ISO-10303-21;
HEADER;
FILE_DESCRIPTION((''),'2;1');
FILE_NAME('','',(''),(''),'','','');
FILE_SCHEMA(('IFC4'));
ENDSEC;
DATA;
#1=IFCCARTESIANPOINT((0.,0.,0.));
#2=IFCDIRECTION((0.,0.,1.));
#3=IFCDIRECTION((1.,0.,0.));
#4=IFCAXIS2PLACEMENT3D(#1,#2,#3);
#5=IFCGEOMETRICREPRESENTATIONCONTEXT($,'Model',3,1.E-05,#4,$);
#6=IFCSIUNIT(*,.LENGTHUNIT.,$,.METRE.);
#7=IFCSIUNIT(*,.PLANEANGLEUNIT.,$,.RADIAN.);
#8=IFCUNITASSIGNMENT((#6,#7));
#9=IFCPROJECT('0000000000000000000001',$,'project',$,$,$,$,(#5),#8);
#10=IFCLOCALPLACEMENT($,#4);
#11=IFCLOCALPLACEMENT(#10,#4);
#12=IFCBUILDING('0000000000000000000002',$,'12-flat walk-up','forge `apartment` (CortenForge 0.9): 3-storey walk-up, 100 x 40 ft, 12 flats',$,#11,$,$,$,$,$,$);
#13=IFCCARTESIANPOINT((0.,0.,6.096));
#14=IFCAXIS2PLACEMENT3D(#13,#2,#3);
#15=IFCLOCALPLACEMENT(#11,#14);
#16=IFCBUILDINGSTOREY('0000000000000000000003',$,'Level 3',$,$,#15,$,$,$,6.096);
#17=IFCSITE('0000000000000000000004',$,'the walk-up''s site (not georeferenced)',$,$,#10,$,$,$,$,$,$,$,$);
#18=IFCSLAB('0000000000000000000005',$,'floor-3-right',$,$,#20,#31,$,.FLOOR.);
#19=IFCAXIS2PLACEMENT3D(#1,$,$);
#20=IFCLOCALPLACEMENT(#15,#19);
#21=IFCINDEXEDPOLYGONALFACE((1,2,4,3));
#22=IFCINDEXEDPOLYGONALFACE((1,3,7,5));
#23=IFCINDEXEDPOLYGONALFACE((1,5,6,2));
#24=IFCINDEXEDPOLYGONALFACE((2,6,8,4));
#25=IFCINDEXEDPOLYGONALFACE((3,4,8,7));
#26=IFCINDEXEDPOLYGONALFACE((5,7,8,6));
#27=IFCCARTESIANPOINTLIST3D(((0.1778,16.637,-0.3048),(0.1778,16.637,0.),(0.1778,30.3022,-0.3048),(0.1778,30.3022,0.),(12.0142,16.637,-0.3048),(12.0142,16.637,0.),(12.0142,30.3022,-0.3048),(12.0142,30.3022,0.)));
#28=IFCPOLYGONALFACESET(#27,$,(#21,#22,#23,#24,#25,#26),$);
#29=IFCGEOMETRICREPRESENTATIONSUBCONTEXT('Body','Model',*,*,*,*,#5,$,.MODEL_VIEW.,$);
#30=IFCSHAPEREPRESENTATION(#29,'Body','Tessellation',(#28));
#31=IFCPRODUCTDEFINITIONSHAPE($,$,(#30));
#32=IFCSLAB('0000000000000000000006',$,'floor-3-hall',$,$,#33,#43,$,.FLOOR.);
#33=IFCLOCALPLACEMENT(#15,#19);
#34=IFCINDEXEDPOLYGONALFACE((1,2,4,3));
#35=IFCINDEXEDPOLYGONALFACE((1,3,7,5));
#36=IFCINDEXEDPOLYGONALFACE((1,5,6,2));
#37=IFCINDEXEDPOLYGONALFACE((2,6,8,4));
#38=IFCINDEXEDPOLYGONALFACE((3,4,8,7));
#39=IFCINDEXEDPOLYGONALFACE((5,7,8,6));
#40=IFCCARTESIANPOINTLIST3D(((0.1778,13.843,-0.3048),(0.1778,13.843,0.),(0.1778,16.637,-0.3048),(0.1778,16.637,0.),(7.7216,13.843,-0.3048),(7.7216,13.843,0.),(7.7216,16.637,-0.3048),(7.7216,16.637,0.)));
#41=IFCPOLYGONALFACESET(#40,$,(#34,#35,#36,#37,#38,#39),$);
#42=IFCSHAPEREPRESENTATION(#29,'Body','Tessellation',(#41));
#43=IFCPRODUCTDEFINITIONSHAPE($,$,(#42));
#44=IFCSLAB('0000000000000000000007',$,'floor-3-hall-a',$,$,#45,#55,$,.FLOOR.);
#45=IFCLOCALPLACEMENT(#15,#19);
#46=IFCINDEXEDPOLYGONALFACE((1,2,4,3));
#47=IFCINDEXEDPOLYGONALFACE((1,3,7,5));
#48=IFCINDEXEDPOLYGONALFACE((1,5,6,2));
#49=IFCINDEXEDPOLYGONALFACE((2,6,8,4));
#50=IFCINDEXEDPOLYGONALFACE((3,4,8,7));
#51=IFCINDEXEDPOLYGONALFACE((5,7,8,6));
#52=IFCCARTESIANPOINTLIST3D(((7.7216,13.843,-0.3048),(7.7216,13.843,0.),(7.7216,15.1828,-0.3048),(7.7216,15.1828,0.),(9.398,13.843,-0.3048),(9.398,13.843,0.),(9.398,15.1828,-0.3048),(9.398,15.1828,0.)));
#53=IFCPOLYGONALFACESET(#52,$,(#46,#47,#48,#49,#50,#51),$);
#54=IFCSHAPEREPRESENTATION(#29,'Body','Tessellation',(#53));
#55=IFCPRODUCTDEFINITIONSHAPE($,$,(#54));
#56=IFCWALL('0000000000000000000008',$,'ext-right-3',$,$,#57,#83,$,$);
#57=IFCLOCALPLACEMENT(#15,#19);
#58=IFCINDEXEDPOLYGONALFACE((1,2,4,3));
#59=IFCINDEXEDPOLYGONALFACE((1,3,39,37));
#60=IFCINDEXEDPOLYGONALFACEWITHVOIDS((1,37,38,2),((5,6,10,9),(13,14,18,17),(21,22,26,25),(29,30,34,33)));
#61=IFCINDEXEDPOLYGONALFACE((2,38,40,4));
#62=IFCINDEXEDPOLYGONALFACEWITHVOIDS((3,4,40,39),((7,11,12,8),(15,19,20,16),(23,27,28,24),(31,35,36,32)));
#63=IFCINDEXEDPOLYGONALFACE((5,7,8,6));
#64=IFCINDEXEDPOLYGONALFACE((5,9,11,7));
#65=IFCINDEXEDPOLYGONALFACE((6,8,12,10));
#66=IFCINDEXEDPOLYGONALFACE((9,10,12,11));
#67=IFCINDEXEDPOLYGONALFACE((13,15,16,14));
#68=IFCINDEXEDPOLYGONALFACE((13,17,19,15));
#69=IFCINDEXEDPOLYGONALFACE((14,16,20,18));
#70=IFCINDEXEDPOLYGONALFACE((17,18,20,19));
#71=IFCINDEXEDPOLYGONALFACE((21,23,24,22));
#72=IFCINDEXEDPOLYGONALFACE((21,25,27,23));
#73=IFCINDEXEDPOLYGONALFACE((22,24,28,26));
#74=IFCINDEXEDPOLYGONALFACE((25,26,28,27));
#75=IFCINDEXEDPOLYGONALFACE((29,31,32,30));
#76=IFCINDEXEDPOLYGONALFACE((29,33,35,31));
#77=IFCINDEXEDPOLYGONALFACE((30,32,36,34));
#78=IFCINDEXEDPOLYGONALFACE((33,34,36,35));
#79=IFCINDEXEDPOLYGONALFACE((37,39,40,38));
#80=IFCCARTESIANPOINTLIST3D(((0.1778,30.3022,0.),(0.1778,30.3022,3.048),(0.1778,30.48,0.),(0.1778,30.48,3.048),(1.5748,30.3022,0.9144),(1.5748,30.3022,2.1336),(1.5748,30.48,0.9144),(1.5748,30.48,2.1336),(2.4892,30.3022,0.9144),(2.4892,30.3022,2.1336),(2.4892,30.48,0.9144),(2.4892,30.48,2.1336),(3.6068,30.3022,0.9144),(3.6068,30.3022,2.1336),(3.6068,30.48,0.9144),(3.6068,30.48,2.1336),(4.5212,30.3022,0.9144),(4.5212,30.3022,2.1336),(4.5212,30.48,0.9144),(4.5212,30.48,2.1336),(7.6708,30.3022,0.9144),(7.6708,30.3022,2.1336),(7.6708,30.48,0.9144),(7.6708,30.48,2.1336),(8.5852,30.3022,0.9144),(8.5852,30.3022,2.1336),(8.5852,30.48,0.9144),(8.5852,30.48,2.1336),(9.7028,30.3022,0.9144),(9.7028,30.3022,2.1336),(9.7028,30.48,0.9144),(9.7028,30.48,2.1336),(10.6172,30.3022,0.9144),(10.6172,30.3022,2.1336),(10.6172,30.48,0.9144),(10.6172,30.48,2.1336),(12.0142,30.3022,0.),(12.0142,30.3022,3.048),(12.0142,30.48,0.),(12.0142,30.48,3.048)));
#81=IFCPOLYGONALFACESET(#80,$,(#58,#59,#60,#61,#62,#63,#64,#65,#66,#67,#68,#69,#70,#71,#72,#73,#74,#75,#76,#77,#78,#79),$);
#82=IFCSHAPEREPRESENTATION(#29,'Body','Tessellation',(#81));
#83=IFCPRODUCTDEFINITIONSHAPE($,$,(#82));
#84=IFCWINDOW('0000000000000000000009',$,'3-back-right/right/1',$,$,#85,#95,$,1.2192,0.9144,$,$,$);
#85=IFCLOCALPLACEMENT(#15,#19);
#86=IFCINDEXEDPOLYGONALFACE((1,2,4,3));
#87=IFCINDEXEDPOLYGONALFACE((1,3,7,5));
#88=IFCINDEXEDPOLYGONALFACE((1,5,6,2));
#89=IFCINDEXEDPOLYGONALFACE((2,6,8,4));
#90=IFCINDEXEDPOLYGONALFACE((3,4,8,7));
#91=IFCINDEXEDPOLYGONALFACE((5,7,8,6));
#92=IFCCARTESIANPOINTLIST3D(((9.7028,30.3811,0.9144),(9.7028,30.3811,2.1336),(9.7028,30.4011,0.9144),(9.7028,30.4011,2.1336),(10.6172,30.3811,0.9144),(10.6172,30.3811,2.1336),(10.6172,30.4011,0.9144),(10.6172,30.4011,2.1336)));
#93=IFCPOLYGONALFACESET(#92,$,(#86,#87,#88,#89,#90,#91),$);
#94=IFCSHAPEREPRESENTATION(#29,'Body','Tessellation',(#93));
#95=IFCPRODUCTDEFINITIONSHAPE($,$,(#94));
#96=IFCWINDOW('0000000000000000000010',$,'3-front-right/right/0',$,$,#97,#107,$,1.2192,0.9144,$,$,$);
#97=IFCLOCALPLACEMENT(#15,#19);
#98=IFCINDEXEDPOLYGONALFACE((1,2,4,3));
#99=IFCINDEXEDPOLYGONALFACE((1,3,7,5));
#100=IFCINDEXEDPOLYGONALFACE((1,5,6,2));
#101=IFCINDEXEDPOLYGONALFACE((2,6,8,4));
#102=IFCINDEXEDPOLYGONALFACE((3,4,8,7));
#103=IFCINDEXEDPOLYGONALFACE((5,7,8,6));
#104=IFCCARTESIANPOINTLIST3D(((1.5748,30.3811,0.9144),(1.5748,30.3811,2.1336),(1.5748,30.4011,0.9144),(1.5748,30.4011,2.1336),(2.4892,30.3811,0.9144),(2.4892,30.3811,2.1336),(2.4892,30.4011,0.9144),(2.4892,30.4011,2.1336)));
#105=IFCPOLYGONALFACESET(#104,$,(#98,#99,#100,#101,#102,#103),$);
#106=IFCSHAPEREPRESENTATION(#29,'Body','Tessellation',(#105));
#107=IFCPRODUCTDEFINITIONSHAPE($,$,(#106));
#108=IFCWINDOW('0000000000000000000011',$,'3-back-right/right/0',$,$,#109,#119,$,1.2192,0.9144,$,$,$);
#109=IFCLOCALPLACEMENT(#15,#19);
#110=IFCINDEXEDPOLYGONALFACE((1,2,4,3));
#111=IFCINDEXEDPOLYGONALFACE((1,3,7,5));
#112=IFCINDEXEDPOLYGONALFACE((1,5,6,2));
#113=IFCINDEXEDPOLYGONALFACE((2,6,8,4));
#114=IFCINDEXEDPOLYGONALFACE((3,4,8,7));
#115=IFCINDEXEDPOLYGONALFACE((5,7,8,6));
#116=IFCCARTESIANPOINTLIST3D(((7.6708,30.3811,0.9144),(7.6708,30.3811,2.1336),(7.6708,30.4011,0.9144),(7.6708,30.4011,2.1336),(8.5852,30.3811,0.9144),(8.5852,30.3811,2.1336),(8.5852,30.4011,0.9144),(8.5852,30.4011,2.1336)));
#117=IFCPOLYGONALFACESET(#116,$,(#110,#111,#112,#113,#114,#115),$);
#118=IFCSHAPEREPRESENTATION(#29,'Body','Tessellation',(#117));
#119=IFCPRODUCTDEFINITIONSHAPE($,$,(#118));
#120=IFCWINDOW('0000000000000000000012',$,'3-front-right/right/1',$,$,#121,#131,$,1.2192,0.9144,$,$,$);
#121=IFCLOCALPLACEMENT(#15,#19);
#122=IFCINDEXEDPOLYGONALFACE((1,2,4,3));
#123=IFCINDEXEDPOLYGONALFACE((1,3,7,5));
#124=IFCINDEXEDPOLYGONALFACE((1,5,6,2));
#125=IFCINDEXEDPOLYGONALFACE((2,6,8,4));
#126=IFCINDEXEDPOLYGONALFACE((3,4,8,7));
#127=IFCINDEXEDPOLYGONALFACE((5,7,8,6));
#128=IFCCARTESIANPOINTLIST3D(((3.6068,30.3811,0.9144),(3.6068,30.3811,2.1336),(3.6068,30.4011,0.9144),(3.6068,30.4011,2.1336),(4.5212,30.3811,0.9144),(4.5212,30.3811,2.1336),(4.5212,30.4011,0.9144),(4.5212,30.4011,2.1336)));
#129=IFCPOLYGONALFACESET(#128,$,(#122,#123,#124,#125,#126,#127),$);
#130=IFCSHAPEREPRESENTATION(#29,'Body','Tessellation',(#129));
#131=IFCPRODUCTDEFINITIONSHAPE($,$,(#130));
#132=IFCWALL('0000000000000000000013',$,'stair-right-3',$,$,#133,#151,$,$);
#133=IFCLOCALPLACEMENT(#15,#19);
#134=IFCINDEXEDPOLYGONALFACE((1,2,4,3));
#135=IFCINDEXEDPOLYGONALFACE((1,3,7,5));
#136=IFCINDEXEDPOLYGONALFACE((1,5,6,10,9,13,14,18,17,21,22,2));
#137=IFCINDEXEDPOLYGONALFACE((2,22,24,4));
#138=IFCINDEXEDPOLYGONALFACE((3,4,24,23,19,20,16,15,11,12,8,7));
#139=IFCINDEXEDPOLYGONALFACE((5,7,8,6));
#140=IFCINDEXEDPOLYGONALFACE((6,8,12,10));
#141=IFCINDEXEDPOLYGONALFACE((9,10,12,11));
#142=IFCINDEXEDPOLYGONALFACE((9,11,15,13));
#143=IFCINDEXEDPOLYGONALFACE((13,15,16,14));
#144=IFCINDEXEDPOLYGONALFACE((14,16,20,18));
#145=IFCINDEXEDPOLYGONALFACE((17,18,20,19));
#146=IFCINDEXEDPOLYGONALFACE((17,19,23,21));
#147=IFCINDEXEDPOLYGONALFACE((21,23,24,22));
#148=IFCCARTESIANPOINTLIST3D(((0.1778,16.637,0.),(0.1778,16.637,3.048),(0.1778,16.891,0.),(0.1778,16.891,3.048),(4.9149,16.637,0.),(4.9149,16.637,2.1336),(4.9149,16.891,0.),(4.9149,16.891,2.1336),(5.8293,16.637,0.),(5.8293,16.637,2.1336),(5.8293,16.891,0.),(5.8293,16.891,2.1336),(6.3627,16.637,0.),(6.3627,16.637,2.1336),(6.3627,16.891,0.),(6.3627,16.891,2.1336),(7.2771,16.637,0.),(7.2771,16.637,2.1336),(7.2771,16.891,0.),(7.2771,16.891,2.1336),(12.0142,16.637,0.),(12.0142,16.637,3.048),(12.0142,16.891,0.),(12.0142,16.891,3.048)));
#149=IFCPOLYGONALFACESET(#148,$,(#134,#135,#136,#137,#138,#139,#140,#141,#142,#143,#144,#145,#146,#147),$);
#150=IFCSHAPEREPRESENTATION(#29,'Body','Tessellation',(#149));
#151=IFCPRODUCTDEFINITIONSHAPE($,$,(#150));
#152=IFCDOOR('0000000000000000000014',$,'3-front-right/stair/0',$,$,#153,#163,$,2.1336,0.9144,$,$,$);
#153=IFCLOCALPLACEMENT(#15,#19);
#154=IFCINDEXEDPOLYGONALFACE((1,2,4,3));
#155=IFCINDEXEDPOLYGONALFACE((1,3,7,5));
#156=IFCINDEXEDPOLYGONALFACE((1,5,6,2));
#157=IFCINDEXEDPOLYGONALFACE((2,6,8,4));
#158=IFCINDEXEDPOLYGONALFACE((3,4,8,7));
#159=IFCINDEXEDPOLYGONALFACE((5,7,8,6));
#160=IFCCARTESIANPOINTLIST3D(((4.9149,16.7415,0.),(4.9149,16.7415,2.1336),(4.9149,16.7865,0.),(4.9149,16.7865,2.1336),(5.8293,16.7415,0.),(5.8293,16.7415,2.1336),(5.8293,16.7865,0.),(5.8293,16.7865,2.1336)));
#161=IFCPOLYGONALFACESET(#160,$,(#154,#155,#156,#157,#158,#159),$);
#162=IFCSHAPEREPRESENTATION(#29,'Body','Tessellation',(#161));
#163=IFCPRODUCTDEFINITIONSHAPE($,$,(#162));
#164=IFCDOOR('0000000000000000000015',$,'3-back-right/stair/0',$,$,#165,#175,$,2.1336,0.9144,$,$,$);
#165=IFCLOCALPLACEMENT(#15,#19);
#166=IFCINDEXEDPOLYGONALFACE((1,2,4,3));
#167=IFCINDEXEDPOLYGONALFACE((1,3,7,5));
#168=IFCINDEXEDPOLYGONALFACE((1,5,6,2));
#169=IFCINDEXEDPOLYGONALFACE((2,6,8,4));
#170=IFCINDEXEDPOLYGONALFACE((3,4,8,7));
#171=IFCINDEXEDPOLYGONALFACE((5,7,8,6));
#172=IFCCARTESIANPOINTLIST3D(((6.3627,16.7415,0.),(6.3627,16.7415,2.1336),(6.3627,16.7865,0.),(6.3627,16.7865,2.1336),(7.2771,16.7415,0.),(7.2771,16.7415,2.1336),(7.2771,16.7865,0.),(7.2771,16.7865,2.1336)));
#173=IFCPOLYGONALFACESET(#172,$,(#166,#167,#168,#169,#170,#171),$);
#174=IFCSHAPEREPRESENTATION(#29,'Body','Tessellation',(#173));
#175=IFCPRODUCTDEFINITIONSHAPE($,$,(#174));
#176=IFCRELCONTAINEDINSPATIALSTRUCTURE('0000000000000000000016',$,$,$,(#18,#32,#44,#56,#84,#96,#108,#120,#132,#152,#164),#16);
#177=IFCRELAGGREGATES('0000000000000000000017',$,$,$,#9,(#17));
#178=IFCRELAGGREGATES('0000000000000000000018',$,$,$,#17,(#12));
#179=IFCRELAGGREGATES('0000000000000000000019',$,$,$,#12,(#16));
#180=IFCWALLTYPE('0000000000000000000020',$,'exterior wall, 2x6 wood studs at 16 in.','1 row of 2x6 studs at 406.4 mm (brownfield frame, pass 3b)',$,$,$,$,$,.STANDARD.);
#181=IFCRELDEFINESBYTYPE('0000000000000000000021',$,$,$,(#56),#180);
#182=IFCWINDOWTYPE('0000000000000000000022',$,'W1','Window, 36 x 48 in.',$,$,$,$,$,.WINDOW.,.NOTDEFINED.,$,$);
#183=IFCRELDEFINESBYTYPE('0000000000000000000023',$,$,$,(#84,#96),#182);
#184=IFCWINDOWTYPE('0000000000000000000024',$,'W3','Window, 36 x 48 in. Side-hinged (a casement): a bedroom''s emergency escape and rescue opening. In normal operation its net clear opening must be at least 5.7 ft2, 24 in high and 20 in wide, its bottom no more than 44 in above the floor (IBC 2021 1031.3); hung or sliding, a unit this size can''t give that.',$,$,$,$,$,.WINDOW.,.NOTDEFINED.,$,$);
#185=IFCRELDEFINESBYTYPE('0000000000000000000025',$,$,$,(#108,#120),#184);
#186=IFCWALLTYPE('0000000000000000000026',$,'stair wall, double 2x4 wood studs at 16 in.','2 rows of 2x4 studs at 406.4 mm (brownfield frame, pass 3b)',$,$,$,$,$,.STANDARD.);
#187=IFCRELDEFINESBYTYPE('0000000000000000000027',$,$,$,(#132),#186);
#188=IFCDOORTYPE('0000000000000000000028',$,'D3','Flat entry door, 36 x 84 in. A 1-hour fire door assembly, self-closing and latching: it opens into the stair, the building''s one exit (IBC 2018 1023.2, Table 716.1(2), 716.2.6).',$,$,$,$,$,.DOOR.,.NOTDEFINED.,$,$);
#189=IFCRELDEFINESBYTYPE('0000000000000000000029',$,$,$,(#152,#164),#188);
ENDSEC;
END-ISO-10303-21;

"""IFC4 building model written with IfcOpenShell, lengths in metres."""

from ifc_helpers import new_model, si_unit, frame, frame_2d, origin, origin_with_axes, place, context, subcontext, project, spatial, rectangle, extrude, type_object, element, fill, save


model = new_model("IFC4")

# Units and contexts
model_context = context("Model", 3, precision=1e-05, world=origin_with_axes())
body_context = subcontext(model_context, "Body", "Model", "MODEL_VIEW")
ifc_project = project(units=[si_unit("LENGTHUNIT", "METRE"), si_unit("PLANEANGLEUNIT", "RADIAN")], contexts=[model_context])

# Site, building, storey
site_placement = place(None, origin_with_axes())
site = spatial("IfcSite", under=ifc_project, at=site_placement, Name="the walk-up's site (not georeferenced)")
building_placement = place(site_placement, origin_with_axes())
building = spatial("IfcBuilding", under=site, at=building_placement, Name="12-flat walk-up", Description="forge `apartment` (CortenForge 0.9): 3-storey walk-up, 100 x 40 ft, 12 flats")
storey_placement = place(building_placement, frame((0.0, 0.0, 6.096), z_axis=(0.0, 0.0, 1.0), x_axis=(1.0, 0.0, 0.0)))
storey = spatial("IfcBuildingStorey", under=building, at=storey_placement, Name="Level 3", Elevation=6.096)

# Slabs
slab_1_placement = place(storey_placement, frame((0.1778, 16.637, -0.3048), z_axis=(0.0, 0.0, 1.0), x_axis=(1.0, 0.0, 0.0)))
element("IfcSlab", 1, at=slab_1_placement, inside=storey, Name="floor-3-right", PredefinedType="FLOOR", context=body_context, shape_type="SweptSolid", body=[
    extrude(rectangle(XDim=11.8364, YDim=13.6652, at=frame_2d((5.9182, 6.8326))), origin(), (0.0, 0.0, 1.0), 0.3048),
])
slab_2_placement = place(storey_placement, frame((0.1778, 13.843, -0.3048), z_axis=(0.0, 0.0, 1.0), x_axis=(1.0, 0.0, 0.0)))
element("IfcSlab", 2, at=slab_2_placement, inside=storey, Name="floor-3-hall", PredefinedType="FLOOR", context=body_context, shape_type="SweptSolid", body=[
    extrude(rectangle(XDim=7.5438, YDim=2.794, at=frame_2d((3.7719, 1.397))), origin(), (0.0, 0.0, 1.0), 0.3048),
])
slab_3_placement = place(storey_placement, frame((7.7216, 13.843, -0.3048), z_axis=(0.0, 0.0, 1.0), x_axis=(1.0, 0.0, 0.0)))
element("IfcSlab", 3, at=slab_3_placement, inside=storey, Name="floor-3-hall-a", PredefinedType="FLOOR", context=body_context, shape_type="SweptSolid", body=[
    extrude(rectangle(XDim=1.6764, YDim=1.3399, at=frame_2d((0.8382, 0.6699))), origin(), (0.0, 0.0, 1.0), 0.3048),
])

# Wall, openings, windows
wall_type_1 = type_object("IfcWallType", Name="exterior wall, 2x6 wood studs at 16 in.", Description="1 row of 2x6 studs at 406.4 mm (brownfield frame, pass 3b)", PredefinedType="STANDARD")
wall_1_placement = place(storey_placement, frame((0.1778, 30.3022, 0.0), z_axis=(0.0, 0.0, 1.0), x_axis=(1.0, 0.0, 0.0)))
wall_1 = element("IfcWall", 4, at=wall_1_placement, inside=storey, type_object=wall_type_1, Name="ext-right-3", context=body_context, shape_type="SweptSolid", body=[
    extrude(rectangle(XDim=11.8364, YDim=0.1778, at=frame_2d((5.9182, 0.0889))), origin(), (0.0, 0.0, 1.0), 3.048),
])
opening_1_placement = place(wall_1_placement, frame((8.4074, 0.1778, 0.9144), z_axis=(0.0, 0.0, 1.0), x_axis=(-1.0, 0.0, 0.0)))
opening_1 = element("IfcOpeningElement", 5, at=opening_1_placement, cuts=wall_1, PredefinedType="OPENING", context=body_context, shape_type="SweptSolid", body=[
    extrude(rectangle(XDim=0.9144, YDim=0.1778, at=frame_2d((0.4572, 0.0889))), origin(), (0.0, 0.0, 1.0), 1.2192),
])
opening_2_placement = place(wall_1_placement, frame((10.4394, 0.1778, 0.9144), z_axis=(0.0, 0.0, 1.0), x_axis=(-1.0, 0.0, 0.0)))
opening_2 = element("IfcOpeningElement", 6, at=opening_2_placement, cuts=wall_1, PredefinedType="OPENING", context=body_context, shape_type="SweptSolid", body=[
    extrude(rectangle(XDim=0.9144, YDim=0.1778, at=frame_2d((0.4572, 0.0889))), origin(), (0.0, 0.0, 1.0), 1.2192),
])
opening_3_placement = place(wall_1_placement, frame((2.3114, 0.1778, 0.9144), z_axis=(0.0, 0.0, 1.0), x_axis=(-1.0, 0.0, 0.0)))
opening_3 = element("IfcOpeningElement", 7, at=opening_3_placement, cuts=wall_1, PredefinedType="OPENING", context=body_context, shape_type="SweptSolid", body=[
    extrude(rectangle(XDim=0.9144, YDim=0.1778, at=frame_2d((0.4572, 0.0889))), origin(), (0.0, 0.0, 1.0), 1.2192),
])
opening_4_placement = place(wall_1_placement, frame((4.3434, 0.1778, 0.9144), z_axis=(0.0, 0.0, 1.0), x_axis=(-1.0, 0.0, 0.0)))
opening_4 = element("IfcOpeningElement", 8, at=opening_4_placement, cuts=wall_1, PredefinedType="OPENING", context=body_context, shape_type="SweptSolid", body=[
    extrude(rectangle(XDim=0.9144, YDim=0.1778, at=frame_2d((0.4572, 0.0889))), origin(), (0.0, 0.0, 1.0), 1.2192),
])
window_type_1 = type_object("IfcWindowType", Name="W1", Description="Window, 36 x 48 in.", PartitioningType="NOTDEFINED", PredefinedType="WINDOW")
window_1_placement = place(opening_2_placement, frame((0.0, 0.0789, 0.0), z_axis=(0.0, 0.0, 1.0), x_axis=(1.0, 0.0, 0.0)))
window_1 = element("IfcWindow", 9, at=window_1_placement, inside=storey, type_object=window_type_1, Name="3-back-right/right/1", OverallHeight=1.2192, OverallWidth=0.9144, context=body_context, shape_type="SweptSolid", body=[
    extrude(rectangle(XDim=0.9144, YDim=0.02, at=frame_2d((0.4572, 0.01))), origin(), (0.0, 0.0, 1.0), 1.2192),
])
fill(opening_2, window_1)
window_2_placement = place(opening_3_placement, frame((0.0, 0.0789, 0.0), z_axis=(0.0, 0.0, 1.0), x_axis=(1.0, 0.0, 0.0)))
window_2 = element("IfcWindow", 10, at=window_2_placement, inside=storey, type_object=window_type_1, Name="3-front-right/right/0", OverallHeight=1.2192, OverallWidth=0.9144, context=body_context, shape_type="SweptSolid", body=[
    extrude(rectangle(XDim=0.9144, YDim=0.02, at=frame_2d((0.4572, 0.01))), origin(), (0.0, 0.0, 1.0), 1.2192),
])
fill(opening_3, window_2)
window_type_2 = type_object("IfcWindowType", Name="W3", Description="Window, 36 x 48 in. Side-hinged (a casement): a bedroom's emergency escape and rescue opening. In normal operation its net clear opening must be at least 5.7 ft2, 24 in high and 20 in wide, its bottom no more than 44 in above the floor (IBC 2021 1031.3); hung or sliding, a unit this size can't give that.", PartitioningType="NOTDEFINED", PredefinedType="WINDOW")
window_3_placement = place(opening_1_placement, frame((0.0, 0.0789, 0.0), z_axis=(0.0, 0.0, 1.0), x_axis=(1.0, 0.0, 0.0)))
window_3 = element("IfcWindow", 11, at=window_3_placement, inside=storey, type_object=window_type_2, Name="3-back-right/right/0", OverallHeight=1.2192, OverallWidth=0.9144, context=body_context, shape_type="SweptSolid", body=[
    extrude(rectangle(XDim=0.9144, YDim=0.02, at=frame_2d((0.4572, 0.01))), origin(), (0.0, 0.0, 1.0), 1.2192),
])
fill(opening_1, window_3)
window_4_placement = place(opening_4_placement, frame((0.0, 0.0789, 0.0), z_axis=(0.0, 0.0, 1.0), x_axis=(1.0, 0.0, 0.0)))
window_4 = element("IfcWindow", 12, at=window_4_placement, inside=storey, type_object=window_type_2, Name="3-front-right/right/1", OverallHeight=1.2192, OverallWidth=0.9144, context=body_context, shape_type="SweptSolid", body=[
    extrude(rectangle(XDim=0.9144, YDim=0.02, at=frame_2d((0.4572, 0.01))), origin(), (0.0, 0.0, 1.0), 1.2192),
])
fill(opening_4, window_4)

# Wall, openings, doors
wall_type_2 = type_object("IfcWallType", Name="stair wall, double 2x4 wood studs at 16 in.", Description="2 rows of 2x4 studs at 406.4 mm (brownfield frame, pass 3b)", PredefinedType="STANDARD")
wall_2_placement = place(storey_placement, frame((0.1778, 16.637, 0.0), z_axis=(0.0, 0.0, 1.0), x_axis=(1.0, 0.0, 0.0)))
wall_2 = element("IfcWall", 13, at=wall_2_placement, inside=storey, type_object=wall_type_2, Name="stair-right-3", context=body_context, shape_type="SweptSolid", body=[
    extrude(rectangle(XDim=11.8364, YDim=0.254, at=frame_2d((5.9182, 0.127))), origin(), (0.0, 0.0, 1.0), 3.048),
])
opening_5_placement = place(wall_2_placement, frame((5.6515, 0.254, 0.0), z_axis=(0.0, 0.0, 1.0), x_axis=(-1.0, 0.0, 0.0)))
opening_5 = element("IfcOpeningElement", 14, at=opening_5_placement, cuts=wall_2, PredefinedType="OPENING", context=body_context, shape_type="SweptSolid", body=[
    extrude(rectangle(XDim=0.9144, YDim=0.254, at=frame_2d((0.4572, 0.127))), origin(), (0.0, 0.0, 1.0), 2.1336),
])
opening_6_placement = place(wall_2_placement, frame((7.0993, 0.254, 0.0), z_axis=(0.0, 0.0, 1.0), x_axis=(-1.0, 0.0, 0.0)))
opening_6 = element("IfcOpeningElement", 15, at=opening_6_placement, cuts=wall_2, PredefinedType="OPENING", context=body_context, shape_type="SweptSolid", body=[
    extrude(rectangle(XDim=0.9144, YDim=0.254, at=frame_2d((0.4572, 0.127))), origin(), (0.0, 0.0, 1.0), 2.1336),
])
door_type = type_object("IfcDoorType", Name="D3", Description="Flat entry door, 36 x 84 in. A 1-hour fire door assembly, self-closing and latching: it opens into the stair, the building's one exit (IBC 2018 1023.2, Table 716.1(2), 716.2.6).", OperationType="NOTDEFINED", PredefinedType="DOOR")
door_1_placement = place(opening_5_placement, frame((0.0, 0.1045, 0.0), z_axis=(0.0, 0.0, 1.0), x_axis=(1.0, 0.0, 0.0)))
door_1 = element("IfcDoor", 16, at=door_1_placement, inside=storey, type_object=door_type, Name="3-front-right/stair/0", OverallHeight=2.1336, OverallWidth=0.9144, context=body_context, shape_type="SweptSolid", body=[
    extrude(rectangle(XDim=0.9144, YDim=0.045, at=frame_2d((0.4572, 0.0225))), origin(), (0.0, 0.0, 1.0), 2.1336),
])
fill(opening_5, door_1)
door_2_placement = place(opening_6_placement, frame((0.0, 0.1045, 0.0), z_axis=(0.0, 0.0, 1.0), x_axis=(1.0, 0.0, 0.0)))
door_2 = element("IfcDoor", 17, at=door_2_placement, inside=storey, type_object=door_type, Name="3-back-right/stair/0", OverallHeight=2.1336, OverallWidth=0.9144, context=body_context, shape_type="SweptSolid", body=[
    extrude(rectangle(XDim=0.9144, YDim=0.045, at=frame_2d((0.4572, 0.0225))), origin(), (0.0, 0.0, 1.0), 2.1336),
])
fill(opening_6, door_2)

save(model, "model.ifc")
